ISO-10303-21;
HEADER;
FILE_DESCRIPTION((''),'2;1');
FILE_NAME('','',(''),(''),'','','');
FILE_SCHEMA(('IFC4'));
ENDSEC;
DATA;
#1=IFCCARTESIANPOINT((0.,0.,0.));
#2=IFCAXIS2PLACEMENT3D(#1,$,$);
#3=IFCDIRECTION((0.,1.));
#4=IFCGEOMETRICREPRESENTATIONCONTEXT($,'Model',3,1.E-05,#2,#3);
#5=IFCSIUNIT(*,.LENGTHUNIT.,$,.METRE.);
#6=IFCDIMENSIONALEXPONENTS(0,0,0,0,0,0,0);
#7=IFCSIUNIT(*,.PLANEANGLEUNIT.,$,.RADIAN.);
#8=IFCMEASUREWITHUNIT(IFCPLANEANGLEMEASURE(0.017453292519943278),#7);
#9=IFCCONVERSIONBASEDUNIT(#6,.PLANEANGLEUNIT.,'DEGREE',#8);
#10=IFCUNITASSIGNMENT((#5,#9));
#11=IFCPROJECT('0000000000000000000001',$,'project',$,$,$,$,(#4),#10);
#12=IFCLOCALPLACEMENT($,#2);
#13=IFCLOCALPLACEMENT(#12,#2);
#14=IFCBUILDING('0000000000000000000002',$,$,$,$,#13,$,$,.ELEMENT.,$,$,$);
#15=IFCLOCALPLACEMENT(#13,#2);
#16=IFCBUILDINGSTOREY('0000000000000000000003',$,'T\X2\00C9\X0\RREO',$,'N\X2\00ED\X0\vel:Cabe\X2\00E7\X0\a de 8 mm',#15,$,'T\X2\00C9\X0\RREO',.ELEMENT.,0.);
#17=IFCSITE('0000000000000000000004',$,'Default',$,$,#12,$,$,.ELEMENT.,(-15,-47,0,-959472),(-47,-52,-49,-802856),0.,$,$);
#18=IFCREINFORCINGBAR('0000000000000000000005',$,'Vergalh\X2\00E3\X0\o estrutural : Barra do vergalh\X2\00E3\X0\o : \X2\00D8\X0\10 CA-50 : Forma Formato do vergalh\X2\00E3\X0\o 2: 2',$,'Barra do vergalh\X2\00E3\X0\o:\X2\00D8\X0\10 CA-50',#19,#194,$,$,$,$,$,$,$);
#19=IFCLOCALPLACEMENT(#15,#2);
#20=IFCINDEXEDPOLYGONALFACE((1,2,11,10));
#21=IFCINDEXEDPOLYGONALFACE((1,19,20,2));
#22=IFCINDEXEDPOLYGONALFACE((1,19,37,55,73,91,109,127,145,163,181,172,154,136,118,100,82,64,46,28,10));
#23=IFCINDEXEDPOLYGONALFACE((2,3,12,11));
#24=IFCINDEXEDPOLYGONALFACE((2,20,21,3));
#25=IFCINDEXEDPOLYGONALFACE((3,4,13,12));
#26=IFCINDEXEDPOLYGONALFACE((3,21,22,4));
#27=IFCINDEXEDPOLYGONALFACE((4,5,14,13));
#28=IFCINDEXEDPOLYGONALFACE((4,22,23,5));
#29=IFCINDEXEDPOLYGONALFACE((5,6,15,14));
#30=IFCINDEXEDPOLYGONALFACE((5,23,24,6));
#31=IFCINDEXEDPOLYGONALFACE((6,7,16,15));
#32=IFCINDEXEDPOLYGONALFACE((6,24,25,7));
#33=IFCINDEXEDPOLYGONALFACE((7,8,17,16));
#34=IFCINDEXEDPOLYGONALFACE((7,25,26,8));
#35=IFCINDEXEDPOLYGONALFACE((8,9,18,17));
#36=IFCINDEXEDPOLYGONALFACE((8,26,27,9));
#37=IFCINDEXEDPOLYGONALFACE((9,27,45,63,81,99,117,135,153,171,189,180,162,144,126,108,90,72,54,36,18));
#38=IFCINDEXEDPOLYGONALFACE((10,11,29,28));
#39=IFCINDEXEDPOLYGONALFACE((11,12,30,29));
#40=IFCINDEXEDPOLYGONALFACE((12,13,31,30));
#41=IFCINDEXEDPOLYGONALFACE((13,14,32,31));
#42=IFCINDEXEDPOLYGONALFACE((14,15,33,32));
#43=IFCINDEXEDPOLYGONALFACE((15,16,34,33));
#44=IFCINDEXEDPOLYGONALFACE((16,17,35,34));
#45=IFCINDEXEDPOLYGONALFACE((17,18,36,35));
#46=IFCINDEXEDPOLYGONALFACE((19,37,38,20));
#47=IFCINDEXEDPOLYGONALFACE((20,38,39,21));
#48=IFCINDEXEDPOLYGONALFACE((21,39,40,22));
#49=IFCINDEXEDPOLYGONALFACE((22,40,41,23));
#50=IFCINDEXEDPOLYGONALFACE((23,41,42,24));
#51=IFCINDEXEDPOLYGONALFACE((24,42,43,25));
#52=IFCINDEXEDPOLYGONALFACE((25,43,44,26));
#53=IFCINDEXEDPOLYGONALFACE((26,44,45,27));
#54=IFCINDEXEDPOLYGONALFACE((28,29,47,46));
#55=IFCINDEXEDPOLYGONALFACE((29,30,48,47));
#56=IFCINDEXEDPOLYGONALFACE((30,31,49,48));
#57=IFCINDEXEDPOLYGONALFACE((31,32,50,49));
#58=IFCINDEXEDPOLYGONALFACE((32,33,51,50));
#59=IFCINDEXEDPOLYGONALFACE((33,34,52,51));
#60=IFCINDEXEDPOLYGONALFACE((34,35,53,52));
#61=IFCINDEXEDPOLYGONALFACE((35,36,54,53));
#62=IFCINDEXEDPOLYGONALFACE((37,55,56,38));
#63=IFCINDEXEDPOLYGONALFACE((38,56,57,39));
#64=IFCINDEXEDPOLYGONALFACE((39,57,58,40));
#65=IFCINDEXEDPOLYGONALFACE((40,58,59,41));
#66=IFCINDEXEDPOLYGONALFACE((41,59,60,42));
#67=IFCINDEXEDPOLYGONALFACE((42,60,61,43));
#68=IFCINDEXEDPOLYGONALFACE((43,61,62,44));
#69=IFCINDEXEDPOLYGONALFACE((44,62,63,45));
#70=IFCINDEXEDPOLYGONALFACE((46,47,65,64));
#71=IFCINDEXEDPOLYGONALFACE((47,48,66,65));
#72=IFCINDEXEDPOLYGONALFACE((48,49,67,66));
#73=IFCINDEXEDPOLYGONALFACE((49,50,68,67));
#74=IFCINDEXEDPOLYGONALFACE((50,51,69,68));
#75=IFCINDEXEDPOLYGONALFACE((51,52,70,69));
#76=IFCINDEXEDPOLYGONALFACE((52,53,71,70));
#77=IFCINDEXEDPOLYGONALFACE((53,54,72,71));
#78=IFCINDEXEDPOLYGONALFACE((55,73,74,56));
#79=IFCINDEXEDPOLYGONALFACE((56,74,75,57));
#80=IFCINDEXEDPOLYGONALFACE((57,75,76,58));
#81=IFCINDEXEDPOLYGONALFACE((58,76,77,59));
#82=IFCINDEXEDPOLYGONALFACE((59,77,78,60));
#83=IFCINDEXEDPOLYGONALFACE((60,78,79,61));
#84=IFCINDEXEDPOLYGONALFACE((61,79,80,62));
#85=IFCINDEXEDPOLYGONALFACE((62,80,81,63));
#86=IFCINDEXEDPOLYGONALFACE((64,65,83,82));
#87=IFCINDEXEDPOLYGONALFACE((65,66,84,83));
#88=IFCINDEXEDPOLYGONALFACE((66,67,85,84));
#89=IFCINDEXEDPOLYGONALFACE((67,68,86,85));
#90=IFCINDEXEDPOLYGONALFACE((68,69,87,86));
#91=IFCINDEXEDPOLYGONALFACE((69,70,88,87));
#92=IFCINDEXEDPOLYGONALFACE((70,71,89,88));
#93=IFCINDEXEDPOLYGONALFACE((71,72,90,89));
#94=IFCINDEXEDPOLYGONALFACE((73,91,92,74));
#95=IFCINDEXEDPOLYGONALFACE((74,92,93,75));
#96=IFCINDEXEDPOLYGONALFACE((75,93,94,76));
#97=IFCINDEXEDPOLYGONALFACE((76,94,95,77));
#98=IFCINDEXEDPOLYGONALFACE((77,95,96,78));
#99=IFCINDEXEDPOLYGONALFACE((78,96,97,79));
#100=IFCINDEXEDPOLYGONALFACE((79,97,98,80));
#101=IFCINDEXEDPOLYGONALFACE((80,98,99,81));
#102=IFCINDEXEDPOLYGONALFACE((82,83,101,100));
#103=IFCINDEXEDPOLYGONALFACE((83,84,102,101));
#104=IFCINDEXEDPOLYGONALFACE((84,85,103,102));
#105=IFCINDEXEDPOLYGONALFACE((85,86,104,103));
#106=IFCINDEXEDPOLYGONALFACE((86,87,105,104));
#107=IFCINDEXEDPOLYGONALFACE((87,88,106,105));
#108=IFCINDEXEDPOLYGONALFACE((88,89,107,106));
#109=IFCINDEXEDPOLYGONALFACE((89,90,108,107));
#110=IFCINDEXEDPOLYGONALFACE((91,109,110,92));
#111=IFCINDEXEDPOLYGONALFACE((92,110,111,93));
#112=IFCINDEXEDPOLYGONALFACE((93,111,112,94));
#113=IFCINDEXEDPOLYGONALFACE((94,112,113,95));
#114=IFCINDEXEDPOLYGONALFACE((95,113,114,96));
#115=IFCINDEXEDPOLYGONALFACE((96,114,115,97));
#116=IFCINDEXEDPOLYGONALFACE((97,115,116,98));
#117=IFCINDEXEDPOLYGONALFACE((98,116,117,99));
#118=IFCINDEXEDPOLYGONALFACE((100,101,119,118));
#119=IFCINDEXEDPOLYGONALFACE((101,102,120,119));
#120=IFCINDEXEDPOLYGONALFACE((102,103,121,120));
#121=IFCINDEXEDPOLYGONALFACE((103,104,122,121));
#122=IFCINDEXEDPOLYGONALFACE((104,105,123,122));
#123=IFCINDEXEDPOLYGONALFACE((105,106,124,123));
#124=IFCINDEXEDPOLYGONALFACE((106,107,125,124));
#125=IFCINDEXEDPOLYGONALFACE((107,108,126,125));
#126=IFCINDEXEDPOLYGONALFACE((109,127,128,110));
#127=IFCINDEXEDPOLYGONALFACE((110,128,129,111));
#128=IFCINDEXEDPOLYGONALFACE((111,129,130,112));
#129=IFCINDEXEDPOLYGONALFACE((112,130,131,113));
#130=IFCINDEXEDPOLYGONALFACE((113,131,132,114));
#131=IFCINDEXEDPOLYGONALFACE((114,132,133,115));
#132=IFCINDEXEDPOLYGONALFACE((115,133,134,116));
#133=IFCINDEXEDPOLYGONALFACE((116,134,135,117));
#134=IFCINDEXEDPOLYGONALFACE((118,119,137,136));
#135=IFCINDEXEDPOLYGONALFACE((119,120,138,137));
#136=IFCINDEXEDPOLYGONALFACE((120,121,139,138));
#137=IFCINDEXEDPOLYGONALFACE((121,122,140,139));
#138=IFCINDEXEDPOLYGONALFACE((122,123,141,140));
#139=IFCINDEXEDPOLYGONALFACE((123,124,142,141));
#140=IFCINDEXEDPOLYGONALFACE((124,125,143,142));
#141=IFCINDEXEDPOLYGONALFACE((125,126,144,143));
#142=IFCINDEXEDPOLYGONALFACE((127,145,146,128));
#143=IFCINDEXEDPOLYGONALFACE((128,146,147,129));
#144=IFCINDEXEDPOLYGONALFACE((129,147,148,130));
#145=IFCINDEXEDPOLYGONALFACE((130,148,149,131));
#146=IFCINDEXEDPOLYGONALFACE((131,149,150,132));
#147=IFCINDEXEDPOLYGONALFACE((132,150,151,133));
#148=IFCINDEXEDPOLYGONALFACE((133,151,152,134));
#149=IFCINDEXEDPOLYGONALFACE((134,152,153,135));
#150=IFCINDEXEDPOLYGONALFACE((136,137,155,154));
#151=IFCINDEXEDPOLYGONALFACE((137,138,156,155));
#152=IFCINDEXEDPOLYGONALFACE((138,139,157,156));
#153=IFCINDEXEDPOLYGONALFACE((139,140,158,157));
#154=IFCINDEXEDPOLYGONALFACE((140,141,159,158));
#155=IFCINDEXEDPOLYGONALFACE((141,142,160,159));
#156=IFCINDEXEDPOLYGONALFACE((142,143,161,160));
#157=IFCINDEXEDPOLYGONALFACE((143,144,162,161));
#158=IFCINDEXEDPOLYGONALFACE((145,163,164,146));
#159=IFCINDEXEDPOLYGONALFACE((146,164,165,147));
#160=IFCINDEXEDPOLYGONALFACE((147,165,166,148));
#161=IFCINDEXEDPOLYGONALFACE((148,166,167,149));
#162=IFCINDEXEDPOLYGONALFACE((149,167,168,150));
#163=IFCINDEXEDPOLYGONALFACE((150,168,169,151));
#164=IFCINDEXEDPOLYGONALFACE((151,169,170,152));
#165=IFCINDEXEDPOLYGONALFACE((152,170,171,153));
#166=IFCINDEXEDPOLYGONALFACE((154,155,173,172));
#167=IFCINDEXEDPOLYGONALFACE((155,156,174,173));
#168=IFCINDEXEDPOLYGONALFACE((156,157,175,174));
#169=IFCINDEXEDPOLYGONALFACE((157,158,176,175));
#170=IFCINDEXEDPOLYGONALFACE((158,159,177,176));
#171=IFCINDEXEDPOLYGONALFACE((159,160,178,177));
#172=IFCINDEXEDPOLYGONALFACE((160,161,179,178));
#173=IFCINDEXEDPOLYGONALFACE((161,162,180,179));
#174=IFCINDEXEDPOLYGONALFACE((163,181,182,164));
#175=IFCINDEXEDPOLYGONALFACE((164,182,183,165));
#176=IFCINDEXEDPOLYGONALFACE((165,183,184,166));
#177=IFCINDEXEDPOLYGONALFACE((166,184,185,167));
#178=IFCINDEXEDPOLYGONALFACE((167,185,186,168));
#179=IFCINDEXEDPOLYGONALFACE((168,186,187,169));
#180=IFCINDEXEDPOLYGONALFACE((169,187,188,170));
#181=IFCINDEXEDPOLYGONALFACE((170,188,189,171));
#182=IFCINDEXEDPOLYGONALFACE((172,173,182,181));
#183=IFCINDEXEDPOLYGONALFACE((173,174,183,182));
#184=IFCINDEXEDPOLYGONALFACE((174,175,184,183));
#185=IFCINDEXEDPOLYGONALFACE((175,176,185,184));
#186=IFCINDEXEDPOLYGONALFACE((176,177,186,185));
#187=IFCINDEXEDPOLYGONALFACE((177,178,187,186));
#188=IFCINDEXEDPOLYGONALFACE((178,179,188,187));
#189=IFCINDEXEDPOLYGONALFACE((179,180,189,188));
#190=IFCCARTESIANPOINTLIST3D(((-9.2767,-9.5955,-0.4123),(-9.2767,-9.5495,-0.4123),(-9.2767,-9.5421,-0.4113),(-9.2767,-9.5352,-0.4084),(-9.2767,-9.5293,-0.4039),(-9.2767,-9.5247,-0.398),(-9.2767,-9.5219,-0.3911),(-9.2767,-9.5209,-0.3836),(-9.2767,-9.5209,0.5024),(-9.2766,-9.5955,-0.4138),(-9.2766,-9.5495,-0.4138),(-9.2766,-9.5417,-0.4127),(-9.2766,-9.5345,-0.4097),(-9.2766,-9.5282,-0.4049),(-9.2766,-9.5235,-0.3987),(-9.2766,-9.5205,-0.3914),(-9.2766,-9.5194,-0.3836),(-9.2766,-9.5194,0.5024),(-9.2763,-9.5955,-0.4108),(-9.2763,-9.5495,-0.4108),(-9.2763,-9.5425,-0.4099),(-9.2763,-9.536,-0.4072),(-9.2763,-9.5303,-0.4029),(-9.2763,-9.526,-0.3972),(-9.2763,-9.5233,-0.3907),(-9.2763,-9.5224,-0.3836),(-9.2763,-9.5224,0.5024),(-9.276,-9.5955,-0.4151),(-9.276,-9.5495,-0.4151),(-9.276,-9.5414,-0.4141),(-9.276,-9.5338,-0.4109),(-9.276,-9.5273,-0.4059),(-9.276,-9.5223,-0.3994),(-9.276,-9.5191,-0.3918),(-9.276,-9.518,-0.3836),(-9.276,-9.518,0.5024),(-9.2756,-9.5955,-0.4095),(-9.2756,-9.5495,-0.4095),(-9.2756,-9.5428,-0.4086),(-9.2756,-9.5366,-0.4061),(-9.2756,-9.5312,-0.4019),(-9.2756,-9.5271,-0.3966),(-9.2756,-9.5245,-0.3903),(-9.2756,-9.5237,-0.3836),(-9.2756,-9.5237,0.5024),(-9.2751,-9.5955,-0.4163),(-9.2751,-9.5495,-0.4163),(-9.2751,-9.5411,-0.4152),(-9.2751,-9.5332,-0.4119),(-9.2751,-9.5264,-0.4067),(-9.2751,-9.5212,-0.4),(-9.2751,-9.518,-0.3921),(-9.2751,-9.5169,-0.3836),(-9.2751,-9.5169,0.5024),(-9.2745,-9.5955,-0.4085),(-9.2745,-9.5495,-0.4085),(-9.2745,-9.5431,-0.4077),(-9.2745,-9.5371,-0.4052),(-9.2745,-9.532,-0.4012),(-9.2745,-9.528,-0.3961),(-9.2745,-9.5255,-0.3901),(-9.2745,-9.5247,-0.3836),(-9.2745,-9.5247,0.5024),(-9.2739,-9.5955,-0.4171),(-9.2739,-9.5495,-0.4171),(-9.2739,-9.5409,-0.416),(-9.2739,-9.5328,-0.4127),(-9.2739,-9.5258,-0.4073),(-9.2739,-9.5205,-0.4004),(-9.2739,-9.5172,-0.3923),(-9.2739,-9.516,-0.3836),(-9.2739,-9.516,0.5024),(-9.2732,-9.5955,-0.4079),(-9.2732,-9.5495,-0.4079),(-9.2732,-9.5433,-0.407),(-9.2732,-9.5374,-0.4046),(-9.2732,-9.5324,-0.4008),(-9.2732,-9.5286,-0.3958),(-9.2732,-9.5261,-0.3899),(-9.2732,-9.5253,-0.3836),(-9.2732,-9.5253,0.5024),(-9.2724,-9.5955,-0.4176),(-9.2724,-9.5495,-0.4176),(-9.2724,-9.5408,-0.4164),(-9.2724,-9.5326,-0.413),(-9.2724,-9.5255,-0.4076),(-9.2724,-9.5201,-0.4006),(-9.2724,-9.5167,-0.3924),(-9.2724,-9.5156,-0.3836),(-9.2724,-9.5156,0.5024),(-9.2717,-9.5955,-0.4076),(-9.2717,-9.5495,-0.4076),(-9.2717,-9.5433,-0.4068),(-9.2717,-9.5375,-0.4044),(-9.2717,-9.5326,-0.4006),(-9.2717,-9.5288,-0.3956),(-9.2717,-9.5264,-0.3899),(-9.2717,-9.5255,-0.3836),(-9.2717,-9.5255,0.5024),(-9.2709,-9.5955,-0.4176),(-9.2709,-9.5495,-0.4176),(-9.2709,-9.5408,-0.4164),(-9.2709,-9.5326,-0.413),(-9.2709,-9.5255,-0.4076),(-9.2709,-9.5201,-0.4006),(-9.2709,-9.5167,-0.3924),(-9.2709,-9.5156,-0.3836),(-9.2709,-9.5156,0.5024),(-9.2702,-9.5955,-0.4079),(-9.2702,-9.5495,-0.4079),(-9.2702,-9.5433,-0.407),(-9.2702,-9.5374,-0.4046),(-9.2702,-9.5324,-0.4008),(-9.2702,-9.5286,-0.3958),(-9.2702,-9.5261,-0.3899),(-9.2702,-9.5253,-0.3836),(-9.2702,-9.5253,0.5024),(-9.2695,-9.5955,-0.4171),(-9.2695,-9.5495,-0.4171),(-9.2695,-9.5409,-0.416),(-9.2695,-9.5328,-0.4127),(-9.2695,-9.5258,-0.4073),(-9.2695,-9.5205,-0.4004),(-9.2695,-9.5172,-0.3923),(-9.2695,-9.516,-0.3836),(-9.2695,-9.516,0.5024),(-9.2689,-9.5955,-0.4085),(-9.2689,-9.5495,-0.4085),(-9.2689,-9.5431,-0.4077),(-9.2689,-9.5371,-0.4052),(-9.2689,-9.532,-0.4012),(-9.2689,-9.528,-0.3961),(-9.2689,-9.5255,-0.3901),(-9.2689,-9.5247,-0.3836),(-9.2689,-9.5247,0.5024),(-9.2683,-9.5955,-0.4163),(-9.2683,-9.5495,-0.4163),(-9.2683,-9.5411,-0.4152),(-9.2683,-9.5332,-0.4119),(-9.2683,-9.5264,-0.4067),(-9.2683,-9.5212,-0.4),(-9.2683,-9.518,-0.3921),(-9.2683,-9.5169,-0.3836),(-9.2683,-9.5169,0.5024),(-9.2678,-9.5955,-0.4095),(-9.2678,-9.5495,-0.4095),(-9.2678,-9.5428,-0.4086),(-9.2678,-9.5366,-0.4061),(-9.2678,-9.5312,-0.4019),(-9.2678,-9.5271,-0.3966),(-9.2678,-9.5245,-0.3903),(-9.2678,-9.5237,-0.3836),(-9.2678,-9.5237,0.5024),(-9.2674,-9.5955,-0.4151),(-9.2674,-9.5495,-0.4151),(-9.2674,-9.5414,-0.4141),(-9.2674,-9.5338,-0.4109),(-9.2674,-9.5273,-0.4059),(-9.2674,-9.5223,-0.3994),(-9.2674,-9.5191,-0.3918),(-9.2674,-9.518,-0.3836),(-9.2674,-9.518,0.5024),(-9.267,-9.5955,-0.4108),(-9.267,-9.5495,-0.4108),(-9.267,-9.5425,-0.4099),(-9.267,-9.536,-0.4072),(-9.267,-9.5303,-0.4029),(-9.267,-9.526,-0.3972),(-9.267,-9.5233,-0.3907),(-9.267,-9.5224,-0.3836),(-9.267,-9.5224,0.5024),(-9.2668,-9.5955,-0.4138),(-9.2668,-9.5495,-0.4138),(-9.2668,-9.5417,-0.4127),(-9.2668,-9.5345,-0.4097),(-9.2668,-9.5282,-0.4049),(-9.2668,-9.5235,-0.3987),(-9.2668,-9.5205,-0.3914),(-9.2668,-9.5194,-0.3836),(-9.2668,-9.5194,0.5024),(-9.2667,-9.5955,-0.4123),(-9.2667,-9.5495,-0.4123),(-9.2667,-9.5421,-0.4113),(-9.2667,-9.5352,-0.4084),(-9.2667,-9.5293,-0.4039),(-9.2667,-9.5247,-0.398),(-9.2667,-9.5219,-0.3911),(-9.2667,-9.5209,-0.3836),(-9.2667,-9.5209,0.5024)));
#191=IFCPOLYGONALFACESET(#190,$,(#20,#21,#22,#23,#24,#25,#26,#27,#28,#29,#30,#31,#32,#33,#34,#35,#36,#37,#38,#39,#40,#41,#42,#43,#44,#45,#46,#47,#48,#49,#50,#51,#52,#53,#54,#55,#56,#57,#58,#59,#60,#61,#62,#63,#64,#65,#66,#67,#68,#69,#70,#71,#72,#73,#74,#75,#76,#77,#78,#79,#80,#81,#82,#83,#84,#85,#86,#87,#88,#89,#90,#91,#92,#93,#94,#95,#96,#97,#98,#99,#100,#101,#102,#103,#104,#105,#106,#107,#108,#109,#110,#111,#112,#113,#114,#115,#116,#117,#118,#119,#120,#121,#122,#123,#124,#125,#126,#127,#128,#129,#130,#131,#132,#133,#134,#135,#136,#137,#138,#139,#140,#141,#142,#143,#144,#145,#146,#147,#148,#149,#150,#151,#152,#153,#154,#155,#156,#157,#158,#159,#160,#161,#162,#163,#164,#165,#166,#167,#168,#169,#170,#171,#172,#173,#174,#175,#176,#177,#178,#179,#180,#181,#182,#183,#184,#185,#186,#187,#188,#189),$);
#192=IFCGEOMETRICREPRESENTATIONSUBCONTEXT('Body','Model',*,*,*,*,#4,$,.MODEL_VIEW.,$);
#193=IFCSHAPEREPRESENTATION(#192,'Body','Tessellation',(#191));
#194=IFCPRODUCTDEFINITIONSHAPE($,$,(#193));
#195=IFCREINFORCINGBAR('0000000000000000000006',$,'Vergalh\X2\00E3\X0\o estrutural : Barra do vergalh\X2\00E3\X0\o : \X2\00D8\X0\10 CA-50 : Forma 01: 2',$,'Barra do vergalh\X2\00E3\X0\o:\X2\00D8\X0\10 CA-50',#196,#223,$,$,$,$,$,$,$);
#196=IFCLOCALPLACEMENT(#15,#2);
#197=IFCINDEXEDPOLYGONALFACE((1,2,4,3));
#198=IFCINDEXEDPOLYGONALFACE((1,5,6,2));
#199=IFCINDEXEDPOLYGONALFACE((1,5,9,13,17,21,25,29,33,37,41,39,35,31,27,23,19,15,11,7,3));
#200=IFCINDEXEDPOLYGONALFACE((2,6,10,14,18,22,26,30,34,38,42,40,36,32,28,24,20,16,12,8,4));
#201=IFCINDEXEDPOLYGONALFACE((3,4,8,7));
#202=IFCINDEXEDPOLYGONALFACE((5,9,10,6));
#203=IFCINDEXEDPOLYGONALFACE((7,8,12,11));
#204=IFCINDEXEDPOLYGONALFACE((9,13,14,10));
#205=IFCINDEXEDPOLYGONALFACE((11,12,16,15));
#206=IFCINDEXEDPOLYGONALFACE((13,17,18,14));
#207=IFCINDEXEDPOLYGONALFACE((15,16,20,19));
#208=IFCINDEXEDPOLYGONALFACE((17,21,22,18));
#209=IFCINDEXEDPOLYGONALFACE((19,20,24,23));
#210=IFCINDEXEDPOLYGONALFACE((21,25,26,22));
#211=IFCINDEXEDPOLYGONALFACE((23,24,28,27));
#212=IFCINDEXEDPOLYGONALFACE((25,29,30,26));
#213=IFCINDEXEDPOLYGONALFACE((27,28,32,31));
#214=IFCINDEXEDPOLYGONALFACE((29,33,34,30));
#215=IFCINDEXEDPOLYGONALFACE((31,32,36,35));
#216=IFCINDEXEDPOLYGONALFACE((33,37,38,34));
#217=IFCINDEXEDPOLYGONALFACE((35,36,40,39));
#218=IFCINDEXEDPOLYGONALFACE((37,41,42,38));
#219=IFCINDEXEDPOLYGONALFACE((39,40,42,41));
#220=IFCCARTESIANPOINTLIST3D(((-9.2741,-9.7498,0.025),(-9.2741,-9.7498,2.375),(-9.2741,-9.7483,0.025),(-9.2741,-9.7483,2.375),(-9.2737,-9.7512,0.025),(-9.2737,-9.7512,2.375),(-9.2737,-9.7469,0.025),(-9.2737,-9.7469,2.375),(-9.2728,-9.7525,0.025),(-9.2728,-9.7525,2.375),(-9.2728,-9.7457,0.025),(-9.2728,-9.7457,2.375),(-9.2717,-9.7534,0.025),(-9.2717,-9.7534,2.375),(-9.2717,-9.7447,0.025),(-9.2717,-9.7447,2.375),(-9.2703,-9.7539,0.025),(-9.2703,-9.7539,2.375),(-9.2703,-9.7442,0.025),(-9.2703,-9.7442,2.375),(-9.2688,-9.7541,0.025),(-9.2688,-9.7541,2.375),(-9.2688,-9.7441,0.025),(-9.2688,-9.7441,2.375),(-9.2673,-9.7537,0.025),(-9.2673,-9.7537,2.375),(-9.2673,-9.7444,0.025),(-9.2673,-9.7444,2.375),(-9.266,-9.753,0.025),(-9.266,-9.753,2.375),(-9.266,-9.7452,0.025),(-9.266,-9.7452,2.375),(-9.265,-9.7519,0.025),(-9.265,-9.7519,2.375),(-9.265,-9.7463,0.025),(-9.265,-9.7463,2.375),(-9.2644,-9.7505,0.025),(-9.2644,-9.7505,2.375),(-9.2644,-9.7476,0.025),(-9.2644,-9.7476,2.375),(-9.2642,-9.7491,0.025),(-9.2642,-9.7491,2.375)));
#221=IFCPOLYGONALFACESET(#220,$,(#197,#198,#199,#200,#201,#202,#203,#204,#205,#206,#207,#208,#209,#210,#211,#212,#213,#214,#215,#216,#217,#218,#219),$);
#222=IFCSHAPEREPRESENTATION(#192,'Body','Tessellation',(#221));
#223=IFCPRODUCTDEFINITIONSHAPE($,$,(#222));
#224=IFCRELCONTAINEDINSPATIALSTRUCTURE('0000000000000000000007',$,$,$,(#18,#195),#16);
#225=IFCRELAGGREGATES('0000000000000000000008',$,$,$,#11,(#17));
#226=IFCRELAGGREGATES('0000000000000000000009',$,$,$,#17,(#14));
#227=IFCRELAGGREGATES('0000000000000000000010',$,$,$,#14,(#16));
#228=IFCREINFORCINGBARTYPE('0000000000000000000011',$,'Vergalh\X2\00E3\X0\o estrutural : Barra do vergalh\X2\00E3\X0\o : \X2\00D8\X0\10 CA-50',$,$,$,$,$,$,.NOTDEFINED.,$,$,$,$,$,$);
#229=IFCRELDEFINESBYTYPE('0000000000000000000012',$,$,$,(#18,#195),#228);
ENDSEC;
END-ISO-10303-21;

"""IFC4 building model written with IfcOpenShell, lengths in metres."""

from ifc_helpers import new_model, entity, si_unit, converted_unit, direction, origin, place, context, subcontext, project, spatial, type_object, element, save


model = new_model("IFC4")

# Units and contexts
model_context = context("Model", 3, precision=1e-05, world=origin(), true_north=direction((0.0, 1.0)))
body_context = subcontext(model_context, "Body", "Model", "MODEL_VIEW")
ifc_project = project(units=[si_unit("LENGTHUNIT", "METRE"), converted_unit("PLANEANGLEUNIT", "DEGREE", entity("IfcPlaneAngleMeasure", 0.017453292519943278), si_unit("PLANEANGLEUNIT", "RADIAN"), dimensions=[0, 0, 0, 0, 0, 0, 0])], contexts=[model_context])

# Site, building, storey
site_placement = place(None, origin())
site = spatial("IfcSite", under=ifc_project, at=site_placement, Name="Default", CompositionType="ELEMENT", RefLatitude=(-15, -47, 0, -959472), RefLongitude=(-47, -52, -49, -802856), RefElevation=0.0)
building_placement = place(site_placement, origin())
building = spatial("IfcBuilding", under=site, at=building_placement, CompositionType="ELEMENT")
storey_placement = place(building_placement, origin())
storey = spatial("IfcBuildingStorey", under=building, at=storey_placement, Name="TÉRREO", ObjectType="Nível:Cabeça de 8 mm", LongName="TÉRREO", CompositionType="ELEMENT", Elevation=0.0)

# Reinforcing bars
reinforcing_bar_type_1 = type_object("IfcReinforcingBarType", Name="Vergalhão estrutural : Barra do vergalhão : Ø10 CA-50", PredefinedType="NOTDEFINED")
reinforcing_bar_1_placement = place(storey_placement, origin())
element("IfcReinforcingBar", 1, at=reinforcing_bar_1_placement, inside=storey, type_object=reinforcing_bar_type_1, Name="Vergalhão estrutural : Barra do vergalhão : Ø10 CA-50 : Forma Formato do vergalhão 2: 2", ObjectType="Barra do vergalhão:Ø10 CA-50", context=body_context, shape_type="AdvancedSweptSolid", body=[
    entity("IfcSweptDiskSolid", entity("IfcIndexedPolyCurve", entity("IfcCartesianPointList3D", [[-9.2717, -9.5955, -0.4126], [-9.2717, -9.5495, -0.4126], [-9.2717, -9.529, -0.4042], [-9.2717, -9.5205, -0.3836], [-9.2717, -9.5205, 0.5024]]), [entity("IfcLineIndex", [1, 2]), entity("IfcArcIndex", [2, 3, 4]), entity("IfcLineIndex", [4, 5])], False), 0.005, None, 0.0, 92.0),
])
reinforcing_bar_2_placement = place(storey_placement, origin())
element("IfcReinforcingBar", 2, at=reinforcing_bar_2_placement, inside=storey, type_object=reinforcing_bar_type_1, Name="Vergalhão estrutural : Barra do vergalhão : Ø10 CA-50 : Forma 01: 2", ObjectType="Barra do vergalhão:Ø10 CA-50", context=body_context, shape_type="AdvancedSweptSolid", body=[
    entity("IfcSweptDiskSolid", entity("IfcIndexedPolyCurve", entity("IfcCartesianPointList3D", [[-9.2692, -9.7491, 0.025], [-9.2692, -9.7491, 2.375]]), None, False), 0.005, None, 0.0, 1.0),
])

save(model, "model.ifc")
